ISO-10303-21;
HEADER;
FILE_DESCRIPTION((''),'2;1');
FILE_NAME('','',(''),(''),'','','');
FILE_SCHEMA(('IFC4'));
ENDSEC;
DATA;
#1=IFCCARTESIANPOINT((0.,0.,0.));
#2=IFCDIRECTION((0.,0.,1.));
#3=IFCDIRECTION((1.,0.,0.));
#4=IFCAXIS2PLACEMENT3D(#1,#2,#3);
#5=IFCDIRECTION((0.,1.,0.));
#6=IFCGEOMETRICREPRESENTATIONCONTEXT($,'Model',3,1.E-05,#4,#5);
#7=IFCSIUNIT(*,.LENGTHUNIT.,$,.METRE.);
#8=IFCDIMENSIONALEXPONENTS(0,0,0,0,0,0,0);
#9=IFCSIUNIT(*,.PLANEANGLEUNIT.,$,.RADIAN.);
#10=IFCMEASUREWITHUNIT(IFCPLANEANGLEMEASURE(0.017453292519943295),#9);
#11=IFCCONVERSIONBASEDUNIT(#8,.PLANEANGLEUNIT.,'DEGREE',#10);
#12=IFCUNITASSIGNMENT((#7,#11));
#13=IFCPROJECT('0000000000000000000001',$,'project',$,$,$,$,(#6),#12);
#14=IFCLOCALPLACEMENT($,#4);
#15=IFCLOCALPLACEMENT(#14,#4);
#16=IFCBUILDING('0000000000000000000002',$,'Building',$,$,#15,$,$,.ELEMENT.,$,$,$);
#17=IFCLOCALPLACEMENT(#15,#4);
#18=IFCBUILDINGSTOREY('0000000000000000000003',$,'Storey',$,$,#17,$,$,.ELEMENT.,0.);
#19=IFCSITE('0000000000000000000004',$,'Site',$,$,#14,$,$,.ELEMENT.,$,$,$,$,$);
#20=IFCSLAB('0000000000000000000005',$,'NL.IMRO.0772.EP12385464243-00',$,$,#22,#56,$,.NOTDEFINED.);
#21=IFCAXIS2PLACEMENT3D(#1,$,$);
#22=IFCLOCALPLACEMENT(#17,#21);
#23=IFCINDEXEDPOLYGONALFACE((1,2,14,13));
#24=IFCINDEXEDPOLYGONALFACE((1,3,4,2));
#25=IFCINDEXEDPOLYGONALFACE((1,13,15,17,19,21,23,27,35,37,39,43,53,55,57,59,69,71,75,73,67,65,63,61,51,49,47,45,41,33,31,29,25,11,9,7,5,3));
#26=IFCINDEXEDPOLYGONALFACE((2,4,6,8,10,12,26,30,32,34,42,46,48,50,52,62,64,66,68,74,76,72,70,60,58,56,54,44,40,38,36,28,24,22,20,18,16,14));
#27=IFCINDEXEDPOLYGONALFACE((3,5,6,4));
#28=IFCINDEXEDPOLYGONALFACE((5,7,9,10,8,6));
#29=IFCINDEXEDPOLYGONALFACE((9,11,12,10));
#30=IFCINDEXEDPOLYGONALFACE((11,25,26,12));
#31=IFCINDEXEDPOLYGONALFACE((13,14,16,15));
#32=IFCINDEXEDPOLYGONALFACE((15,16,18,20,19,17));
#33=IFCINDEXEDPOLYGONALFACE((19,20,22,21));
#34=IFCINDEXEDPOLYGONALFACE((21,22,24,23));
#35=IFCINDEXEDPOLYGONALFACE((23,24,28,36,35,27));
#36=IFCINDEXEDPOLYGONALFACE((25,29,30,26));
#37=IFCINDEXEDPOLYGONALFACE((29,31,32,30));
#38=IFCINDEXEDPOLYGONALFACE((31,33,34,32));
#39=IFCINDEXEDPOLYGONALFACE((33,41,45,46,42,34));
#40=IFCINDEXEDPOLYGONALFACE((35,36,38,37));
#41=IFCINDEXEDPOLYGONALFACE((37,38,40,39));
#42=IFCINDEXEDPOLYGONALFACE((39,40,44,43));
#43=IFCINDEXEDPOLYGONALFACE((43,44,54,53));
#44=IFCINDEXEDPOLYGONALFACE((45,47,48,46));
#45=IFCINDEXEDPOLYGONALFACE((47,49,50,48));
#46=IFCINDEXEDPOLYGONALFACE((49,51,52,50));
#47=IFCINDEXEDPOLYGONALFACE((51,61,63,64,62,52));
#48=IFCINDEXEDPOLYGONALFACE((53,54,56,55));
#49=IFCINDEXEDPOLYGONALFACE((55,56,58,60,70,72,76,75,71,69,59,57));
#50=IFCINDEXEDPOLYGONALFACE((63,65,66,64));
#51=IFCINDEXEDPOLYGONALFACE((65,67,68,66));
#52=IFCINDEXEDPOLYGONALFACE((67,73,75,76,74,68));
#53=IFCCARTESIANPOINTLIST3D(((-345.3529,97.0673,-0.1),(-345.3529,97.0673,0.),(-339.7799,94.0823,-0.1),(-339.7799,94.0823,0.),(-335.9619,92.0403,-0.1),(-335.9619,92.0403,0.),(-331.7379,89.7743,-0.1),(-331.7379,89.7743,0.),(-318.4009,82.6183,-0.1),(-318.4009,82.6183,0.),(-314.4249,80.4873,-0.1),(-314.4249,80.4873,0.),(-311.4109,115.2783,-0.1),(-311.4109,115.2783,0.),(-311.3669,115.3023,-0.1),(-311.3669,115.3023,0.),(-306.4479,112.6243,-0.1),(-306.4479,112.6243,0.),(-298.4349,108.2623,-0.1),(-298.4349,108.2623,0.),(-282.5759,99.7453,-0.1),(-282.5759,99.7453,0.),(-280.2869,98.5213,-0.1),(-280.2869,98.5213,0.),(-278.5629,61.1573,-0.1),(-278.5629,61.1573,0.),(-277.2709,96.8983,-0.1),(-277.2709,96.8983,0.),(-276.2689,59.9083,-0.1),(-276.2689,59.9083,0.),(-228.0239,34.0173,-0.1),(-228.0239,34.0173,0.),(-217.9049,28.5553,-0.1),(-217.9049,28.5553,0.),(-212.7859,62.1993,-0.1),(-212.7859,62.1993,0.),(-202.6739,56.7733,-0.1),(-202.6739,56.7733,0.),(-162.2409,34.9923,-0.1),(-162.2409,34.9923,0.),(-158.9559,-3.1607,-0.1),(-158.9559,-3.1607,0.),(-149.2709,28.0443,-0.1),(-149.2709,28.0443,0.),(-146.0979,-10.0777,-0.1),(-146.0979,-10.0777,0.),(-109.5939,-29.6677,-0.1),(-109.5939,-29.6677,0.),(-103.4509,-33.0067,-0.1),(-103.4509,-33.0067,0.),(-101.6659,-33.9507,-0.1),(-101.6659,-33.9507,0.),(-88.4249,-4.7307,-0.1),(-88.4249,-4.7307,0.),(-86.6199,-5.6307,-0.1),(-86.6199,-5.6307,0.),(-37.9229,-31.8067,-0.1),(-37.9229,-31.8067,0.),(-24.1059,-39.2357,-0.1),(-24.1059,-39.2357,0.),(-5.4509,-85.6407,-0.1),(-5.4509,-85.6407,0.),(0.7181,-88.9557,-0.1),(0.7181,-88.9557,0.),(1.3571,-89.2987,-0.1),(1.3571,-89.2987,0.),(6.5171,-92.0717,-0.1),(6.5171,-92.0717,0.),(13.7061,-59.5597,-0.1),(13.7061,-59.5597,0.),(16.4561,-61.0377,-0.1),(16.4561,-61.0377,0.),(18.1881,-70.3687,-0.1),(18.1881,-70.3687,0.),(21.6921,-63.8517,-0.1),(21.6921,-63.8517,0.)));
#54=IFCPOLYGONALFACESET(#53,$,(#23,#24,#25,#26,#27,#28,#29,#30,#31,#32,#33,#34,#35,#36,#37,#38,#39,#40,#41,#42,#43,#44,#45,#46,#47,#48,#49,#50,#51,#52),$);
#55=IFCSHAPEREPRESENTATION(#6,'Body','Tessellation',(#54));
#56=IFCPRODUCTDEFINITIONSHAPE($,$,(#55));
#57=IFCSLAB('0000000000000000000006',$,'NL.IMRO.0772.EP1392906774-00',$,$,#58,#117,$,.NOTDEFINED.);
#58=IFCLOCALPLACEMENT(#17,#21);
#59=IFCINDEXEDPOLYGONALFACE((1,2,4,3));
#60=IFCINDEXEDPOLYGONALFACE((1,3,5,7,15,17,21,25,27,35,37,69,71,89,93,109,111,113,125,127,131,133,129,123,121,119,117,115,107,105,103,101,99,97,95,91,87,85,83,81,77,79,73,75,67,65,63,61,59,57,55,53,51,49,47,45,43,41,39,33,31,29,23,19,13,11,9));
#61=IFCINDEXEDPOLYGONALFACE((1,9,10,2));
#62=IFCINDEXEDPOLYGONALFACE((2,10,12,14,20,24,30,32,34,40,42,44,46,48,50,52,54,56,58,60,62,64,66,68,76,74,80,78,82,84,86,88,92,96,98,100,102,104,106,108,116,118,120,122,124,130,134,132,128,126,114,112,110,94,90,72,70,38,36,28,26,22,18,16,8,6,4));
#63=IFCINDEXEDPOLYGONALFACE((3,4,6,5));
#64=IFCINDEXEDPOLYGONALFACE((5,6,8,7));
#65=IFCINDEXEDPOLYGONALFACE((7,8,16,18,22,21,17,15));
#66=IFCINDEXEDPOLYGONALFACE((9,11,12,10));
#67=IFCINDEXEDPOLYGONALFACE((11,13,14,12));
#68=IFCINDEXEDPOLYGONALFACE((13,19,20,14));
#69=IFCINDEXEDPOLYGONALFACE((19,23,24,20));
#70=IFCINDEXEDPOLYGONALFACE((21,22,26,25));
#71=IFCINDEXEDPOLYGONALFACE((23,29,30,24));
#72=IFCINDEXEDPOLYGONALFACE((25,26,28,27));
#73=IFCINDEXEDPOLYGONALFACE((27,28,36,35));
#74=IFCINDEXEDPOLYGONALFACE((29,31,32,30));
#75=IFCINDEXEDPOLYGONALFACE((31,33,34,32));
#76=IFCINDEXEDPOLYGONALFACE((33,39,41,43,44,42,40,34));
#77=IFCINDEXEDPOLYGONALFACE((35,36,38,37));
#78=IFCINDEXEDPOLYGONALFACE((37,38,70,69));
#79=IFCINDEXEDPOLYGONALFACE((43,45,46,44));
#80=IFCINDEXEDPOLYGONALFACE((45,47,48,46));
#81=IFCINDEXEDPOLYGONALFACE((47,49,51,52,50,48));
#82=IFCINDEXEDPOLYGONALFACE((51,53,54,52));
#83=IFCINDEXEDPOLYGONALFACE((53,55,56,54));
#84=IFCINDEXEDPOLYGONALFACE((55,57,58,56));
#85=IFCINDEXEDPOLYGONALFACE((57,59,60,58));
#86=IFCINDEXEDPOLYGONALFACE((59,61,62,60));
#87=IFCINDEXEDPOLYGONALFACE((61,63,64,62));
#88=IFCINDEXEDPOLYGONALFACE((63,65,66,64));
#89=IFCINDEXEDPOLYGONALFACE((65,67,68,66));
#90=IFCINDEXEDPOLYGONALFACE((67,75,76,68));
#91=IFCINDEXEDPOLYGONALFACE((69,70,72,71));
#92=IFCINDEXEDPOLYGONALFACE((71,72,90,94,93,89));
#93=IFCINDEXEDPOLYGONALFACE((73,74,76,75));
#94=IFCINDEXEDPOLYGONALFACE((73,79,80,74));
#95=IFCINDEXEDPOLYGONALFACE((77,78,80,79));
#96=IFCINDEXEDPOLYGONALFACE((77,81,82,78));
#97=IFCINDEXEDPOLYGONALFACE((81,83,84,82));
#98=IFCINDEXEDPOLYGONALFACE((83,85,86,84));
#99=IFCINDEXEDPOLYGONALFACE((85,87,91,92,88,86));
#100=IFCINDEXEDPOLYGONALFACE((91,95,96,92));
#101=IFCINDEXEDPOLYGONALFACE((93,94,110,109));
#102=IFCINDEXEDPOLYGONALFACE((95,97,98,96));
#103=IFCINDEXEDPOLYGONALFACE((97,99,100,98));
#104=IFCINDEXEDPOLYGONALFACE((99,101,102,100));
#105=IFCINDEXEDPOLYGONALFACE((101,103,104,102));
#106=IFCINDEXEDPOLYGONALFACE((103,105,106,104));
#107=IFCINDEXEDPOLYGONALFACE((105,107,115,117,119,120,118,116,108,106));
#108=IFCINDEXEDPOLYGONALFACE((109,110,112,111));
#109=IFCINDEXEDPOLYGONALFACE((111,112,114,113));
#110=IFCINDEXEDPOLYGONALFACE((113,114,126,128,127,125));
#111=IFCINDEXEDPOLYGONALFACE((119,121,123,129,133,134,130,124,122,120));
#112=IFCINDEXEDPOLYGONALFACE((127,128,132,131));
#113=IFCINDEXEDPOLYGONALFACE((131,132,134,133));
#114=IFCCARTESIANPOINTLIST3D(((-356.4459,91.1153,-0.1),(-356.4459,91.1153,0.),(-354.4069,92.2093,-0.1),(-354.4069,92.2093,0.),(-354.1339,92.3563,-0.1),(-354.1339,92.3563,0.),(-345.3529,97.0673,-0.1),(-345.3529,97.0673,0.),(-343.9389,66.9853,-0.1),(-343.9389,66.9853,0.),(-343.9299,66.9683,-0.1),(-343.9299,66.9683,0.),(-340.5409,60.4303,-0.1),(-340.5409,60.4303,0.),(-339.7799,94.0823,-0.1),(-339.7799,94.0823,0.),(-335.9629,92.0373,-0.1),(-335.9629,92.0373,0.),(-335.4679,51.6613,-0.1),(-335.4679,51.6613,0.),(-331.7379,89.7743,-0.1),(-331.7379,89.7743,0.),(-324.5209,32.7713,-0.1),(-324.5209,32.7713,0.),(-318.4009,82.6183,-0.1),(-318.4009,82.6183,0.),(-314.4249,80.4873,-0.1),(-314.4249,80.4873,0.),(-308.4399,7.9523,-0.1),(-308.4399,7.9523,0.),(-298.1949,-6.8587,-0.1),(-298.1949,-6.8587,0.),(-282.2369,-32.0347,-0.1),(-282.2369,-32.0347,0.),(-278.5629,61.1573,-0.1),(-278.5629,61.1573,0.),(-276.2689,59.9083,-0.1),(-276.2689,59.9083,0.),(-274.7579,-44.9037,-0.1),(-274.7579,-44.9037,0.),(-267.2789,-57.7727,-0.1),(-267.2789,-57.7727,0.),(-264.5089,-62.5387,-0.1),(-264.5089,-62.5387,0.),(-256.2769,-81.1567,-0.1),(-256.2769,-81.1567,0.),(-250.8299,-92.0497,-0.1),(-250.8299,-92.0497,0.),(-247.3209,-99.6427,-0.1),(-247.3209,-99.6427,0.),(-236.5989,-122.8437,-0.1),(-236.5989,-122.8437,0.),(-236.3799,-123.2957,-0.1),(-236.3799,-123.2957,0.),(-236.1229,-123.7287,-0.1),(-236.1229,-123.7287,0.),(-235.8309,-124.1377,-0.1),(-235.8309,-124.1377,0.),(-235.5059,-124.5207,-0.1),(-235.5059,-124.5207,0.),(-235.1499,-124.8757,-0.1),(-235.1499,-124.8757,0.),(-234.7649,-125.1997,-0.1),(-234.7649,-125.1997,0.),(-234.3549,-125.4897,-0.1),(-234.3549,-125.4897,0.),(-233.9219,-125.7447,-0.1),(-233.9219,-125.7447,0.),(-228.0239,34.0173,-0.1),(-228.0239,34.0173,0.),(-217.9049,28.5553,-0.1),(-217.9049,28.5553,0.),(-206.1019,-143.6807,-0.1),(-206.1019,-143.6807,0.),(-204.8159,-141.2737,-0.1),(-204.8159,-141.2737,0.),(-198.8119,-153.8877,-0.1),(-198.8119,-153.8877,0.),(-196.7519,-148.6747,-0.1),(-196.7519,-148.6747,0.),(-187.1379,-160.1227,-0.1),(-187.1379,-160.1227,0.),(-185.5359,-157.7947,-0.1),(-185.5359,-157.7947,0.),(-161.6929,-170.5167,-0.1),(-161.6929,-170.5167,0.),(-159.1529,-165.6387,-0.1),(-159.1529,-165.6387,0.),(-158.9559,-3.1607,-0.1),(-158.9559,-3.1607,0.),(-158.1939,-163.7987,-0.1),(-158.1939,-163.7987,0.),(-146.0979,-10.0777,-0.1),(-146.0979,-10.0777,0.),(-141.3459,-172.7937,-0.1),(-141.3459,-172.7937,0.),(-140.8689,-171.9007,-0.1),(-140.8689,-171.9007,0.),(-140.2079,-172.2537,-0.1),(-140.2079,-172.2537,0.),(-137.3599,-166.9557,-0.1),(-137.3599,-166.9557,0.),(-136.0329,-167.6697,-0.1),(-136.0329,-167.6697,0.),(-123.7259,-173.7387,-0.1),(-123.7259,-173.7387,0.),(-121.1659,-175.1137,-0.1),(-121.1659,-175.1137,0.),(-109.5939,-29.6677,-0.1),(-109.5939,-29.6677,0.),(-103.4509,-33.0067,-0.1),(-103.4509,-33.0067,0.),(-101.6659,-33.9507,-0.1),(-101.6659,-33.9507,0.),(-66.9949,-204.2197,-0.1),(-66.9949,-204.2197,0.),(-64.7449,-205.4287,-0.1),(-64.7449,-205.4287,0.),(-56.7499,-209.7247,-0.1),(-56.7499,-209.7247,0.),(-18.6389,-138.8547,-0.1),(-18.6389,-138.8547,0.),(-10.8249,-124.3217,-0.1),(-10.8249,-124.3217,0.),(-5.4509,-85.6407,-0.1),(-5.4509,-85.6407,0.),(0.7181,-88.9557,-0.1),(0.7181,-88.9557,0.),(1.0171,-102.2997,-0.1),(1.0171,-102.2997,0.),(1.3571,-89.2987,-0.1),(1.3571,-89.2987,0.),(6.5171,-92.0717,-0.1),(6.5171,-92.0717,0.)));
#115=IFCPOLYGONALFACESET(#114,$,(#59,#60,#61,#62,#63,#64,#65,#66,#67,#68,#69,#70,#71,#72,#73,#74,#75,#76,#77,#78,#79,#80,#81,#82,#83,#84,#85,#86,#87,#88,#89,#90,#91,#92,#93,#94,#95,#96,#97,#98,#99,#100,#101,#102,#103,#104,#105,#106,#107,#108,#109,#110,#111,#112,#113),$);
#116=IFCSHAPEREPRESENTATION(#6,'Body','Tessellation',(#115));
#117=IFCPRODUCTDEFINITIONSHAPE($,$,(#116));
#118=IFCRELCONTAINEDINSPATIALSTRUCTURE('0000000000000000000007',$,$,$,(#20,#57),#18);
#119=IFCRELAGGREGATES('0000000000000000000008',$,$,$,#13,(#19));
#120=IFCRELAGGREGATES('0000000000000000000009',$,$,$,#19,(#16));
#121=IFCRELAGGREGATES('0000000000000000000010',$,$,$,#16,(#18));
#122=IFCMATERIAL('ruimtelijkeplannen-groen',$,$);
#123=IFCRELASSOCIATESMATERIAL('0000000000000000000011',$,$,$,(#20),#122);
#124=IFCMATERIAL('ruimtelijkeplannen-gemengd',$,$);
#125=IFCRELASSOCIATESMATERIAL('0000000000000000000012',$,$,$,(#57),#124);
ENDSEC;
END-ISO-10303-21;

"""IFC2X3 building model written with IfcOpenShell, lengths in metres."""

from ifc_helpers import new_model, entity, si_unit, converted_unit, direction, frame, origin_with_axes, place, context, project, spatial, polyline, outline, extrude, material, element, save


model = new_model("IFC2X3")

# Units and contexts
model_context = context("Model", 3, precision=1e-05, world=origin_with_axes(), true_north=direction((0.0, 1.0, 0.0)))
ifc_project = project(units=[si_unit("LENGTHUNIT", "METRE"), converted_unit("PLANEANGLEUNIT", "DEGREE", entity("IfcPlaneAngleMeasure", 0.017453292519943295), si_unit("PLANEANGLEUNIT", "RADIAN"), dimensions=[0, 0, 0, 0, 0, 0, 0])], contexts=[model_context])

# Site, building, storey
site_placement = place(None, origin_with_axes())
site = spatial("IfcSite", under=ifc_project, at=site_placement, Name="Site", CompositionType="ELEMENT")
building_placement = place(site_placement, origin_with_axes())
building = spatial("IfcBuilding", under=site, at=building_placement, Name="Building", CompositionType="ELEMENT")
storey_placement = place(building_placement, origin_with_axes())
storey = spatial("IfcBuildingStorey", under=building, at=storey_placement, Name="Storey", CompositionType="ELEMENT", Elevation=0.0)

# Slabs
ifc_material_1 = material(Name="ruimtelijkeplannen-groen")
ifc_material_2 = material(Name="ruimtelijkeplannen-gemengd")
slab_1_placement = place(storey_placement, frame((0.0, 0.0, -0.1), z_axis=(0.0, 0.0, 1.0), x_axis=(1.0, 0.0, 0.0)))
element("IfcSlab", 1, at=slab_1_placement, inside=storey, material=ifc_material_1, Name="NL.IMRO.0772.EP12385464243-00", PredefinedType="NOTDEFINED", context=model_context, shape_type="SweptSolid", body=[
    extrude(outline(polyline([(21.6921, -63.8517), (18.1881, -70.3687), (6.5171, -92.0717), (1.3571, -89.2987), (0.7181, -88.9557), (-5.4509, -85.6407), (-101.6659, -33.9507), (-103.4509, -33.0067), (-109.5939, -29.6677), (-146.0979, -10.0777), (-158.9559, -3.1607), (-217.9049, 28.5553), (-228.0239, 34.0173), (-276.2689, 59.9083), (-278.5629, 61.1573), (-314.4249, 80.4873), (-318.4009, 82.6183), (-331.7379, 89.7743), (-335.9619, 92.0403), (-339.7799, 94.0823), (-345.3529, 97.0673), (-311.4109, 115.2783), (-311.3669, 115.3023), (-306.4479, 112.6243), (-298.4349, 108.2623), (-282.5759, 99.7453), (-280.2869, 98.5213), (-277.2709, 96.8983), (-212.7859, 62.1993), (-202.6739, 56.7733), (-162.2409, 34.9923), (-149.2709, 28.0443), (-88.4249, -4.7307), (-86.6199, -5.6307), (-37.9229, -31.8067), (-24.1059, -39.2357), (13.7061, -59.5597), (16.4561, -61.0377), (21.6921, -63.8517)])), origin_with_axes(), (0.0, 0.0, 1.0), 0.1),
])
slab_2_placement = place(storey_placement, frame((0.0, 0.0, -0.1), z_axis=(0.0, 0.0, 1.0), x_axis=(1.0, 0.0, 0.0)))
element("IfcSlab", 2, at=slab_2_placement, inside=storey, material=ifc_material_2, Name="NL.IMRO.0772.EP1392906774-00", PredefinedType="NOTDEFINED", context=model_context, shape_type="SweptSolid", body=[
    extrude(outline(polyline([(-339.7799, 94.0823), (-335.9629, 92.0373), (-331.7379, 89.7743), (-318.4009, 82.6183), (-314.4249, 80.4873), (-278.5629, 61.1573), (-276.2689, 59.9083), (-228.0239, 34.0173), (-217.9049, 28.5553), (-158.9559, -3.1607), (-146.0979, -10.0777), (-109.5939, -29.6677), (-103.4509, -33.0067), (-101.6659, -33.9507), (-5.4509, -85.6407), (0.7181, -88.9557), (1.3571, -89.2987), (6.5171, -92.0717), (1.0171, -102.2997), (-10.8249, -124.3217), (-18.6389, -138.8547), (-56.7499, -209.7247), (-64.7449, -205.4287), (-66.9949, -204.2197), (-121.1659, -175.1137), (-123.7259, -173.7387), (-136.0329, -167.6697), (-137.3599, -166.9557), (-140.2079, -172.2537), (-140.8689, -171.9007), (-141.3459, -172.7937), (-158.1939, -163.7987), (-159.1529, -165.6387), (-161.6929, -170.5167), (-185.5359, -157.7947), (-187.1379, -160.1227), (-198.8119, -153.8877), (-196.7519, -148.6747), (-206.1019, -143.6807), (-204.8159, -141.2737), (-233.9219, -125.7447), (-234.3549, -125.4897), (-234.7649, -125.1997), (-235.1499, -124.8757), (-235.5059, -124.5207), (-235.8309, -124.1377), (-236.1229, -123.7287), (-236.3799, -123.2957), (-236.5989, -122.8437), (-247.3209, -99.6427), (-250.8299, -92.0497), (-256.2769, -81.1567), (-264.5089, -62.5387), (-267.2789, -57.7727), (-274.7579, -44.9037), (-282.2369, -32.0347), (-298.1949, -6.8587), (-308.4399, 7.9523), (-324.5209, 32.7713), (-335.4679, 51.6613), (-340.5409, 60.4303), (-343.9299, 66.9683), (-343.9389, 66.9853), (-356.4459, 91.1153), (-354.4069, 92.2093), (-354.1339, 92.3563), (-345.3529, 97.0673), (-339.7799, 94.0823)])), origin_with_axes(), (0.0, 0.0, 1.0), 0.1),
])

save(model, "model.ifc")
